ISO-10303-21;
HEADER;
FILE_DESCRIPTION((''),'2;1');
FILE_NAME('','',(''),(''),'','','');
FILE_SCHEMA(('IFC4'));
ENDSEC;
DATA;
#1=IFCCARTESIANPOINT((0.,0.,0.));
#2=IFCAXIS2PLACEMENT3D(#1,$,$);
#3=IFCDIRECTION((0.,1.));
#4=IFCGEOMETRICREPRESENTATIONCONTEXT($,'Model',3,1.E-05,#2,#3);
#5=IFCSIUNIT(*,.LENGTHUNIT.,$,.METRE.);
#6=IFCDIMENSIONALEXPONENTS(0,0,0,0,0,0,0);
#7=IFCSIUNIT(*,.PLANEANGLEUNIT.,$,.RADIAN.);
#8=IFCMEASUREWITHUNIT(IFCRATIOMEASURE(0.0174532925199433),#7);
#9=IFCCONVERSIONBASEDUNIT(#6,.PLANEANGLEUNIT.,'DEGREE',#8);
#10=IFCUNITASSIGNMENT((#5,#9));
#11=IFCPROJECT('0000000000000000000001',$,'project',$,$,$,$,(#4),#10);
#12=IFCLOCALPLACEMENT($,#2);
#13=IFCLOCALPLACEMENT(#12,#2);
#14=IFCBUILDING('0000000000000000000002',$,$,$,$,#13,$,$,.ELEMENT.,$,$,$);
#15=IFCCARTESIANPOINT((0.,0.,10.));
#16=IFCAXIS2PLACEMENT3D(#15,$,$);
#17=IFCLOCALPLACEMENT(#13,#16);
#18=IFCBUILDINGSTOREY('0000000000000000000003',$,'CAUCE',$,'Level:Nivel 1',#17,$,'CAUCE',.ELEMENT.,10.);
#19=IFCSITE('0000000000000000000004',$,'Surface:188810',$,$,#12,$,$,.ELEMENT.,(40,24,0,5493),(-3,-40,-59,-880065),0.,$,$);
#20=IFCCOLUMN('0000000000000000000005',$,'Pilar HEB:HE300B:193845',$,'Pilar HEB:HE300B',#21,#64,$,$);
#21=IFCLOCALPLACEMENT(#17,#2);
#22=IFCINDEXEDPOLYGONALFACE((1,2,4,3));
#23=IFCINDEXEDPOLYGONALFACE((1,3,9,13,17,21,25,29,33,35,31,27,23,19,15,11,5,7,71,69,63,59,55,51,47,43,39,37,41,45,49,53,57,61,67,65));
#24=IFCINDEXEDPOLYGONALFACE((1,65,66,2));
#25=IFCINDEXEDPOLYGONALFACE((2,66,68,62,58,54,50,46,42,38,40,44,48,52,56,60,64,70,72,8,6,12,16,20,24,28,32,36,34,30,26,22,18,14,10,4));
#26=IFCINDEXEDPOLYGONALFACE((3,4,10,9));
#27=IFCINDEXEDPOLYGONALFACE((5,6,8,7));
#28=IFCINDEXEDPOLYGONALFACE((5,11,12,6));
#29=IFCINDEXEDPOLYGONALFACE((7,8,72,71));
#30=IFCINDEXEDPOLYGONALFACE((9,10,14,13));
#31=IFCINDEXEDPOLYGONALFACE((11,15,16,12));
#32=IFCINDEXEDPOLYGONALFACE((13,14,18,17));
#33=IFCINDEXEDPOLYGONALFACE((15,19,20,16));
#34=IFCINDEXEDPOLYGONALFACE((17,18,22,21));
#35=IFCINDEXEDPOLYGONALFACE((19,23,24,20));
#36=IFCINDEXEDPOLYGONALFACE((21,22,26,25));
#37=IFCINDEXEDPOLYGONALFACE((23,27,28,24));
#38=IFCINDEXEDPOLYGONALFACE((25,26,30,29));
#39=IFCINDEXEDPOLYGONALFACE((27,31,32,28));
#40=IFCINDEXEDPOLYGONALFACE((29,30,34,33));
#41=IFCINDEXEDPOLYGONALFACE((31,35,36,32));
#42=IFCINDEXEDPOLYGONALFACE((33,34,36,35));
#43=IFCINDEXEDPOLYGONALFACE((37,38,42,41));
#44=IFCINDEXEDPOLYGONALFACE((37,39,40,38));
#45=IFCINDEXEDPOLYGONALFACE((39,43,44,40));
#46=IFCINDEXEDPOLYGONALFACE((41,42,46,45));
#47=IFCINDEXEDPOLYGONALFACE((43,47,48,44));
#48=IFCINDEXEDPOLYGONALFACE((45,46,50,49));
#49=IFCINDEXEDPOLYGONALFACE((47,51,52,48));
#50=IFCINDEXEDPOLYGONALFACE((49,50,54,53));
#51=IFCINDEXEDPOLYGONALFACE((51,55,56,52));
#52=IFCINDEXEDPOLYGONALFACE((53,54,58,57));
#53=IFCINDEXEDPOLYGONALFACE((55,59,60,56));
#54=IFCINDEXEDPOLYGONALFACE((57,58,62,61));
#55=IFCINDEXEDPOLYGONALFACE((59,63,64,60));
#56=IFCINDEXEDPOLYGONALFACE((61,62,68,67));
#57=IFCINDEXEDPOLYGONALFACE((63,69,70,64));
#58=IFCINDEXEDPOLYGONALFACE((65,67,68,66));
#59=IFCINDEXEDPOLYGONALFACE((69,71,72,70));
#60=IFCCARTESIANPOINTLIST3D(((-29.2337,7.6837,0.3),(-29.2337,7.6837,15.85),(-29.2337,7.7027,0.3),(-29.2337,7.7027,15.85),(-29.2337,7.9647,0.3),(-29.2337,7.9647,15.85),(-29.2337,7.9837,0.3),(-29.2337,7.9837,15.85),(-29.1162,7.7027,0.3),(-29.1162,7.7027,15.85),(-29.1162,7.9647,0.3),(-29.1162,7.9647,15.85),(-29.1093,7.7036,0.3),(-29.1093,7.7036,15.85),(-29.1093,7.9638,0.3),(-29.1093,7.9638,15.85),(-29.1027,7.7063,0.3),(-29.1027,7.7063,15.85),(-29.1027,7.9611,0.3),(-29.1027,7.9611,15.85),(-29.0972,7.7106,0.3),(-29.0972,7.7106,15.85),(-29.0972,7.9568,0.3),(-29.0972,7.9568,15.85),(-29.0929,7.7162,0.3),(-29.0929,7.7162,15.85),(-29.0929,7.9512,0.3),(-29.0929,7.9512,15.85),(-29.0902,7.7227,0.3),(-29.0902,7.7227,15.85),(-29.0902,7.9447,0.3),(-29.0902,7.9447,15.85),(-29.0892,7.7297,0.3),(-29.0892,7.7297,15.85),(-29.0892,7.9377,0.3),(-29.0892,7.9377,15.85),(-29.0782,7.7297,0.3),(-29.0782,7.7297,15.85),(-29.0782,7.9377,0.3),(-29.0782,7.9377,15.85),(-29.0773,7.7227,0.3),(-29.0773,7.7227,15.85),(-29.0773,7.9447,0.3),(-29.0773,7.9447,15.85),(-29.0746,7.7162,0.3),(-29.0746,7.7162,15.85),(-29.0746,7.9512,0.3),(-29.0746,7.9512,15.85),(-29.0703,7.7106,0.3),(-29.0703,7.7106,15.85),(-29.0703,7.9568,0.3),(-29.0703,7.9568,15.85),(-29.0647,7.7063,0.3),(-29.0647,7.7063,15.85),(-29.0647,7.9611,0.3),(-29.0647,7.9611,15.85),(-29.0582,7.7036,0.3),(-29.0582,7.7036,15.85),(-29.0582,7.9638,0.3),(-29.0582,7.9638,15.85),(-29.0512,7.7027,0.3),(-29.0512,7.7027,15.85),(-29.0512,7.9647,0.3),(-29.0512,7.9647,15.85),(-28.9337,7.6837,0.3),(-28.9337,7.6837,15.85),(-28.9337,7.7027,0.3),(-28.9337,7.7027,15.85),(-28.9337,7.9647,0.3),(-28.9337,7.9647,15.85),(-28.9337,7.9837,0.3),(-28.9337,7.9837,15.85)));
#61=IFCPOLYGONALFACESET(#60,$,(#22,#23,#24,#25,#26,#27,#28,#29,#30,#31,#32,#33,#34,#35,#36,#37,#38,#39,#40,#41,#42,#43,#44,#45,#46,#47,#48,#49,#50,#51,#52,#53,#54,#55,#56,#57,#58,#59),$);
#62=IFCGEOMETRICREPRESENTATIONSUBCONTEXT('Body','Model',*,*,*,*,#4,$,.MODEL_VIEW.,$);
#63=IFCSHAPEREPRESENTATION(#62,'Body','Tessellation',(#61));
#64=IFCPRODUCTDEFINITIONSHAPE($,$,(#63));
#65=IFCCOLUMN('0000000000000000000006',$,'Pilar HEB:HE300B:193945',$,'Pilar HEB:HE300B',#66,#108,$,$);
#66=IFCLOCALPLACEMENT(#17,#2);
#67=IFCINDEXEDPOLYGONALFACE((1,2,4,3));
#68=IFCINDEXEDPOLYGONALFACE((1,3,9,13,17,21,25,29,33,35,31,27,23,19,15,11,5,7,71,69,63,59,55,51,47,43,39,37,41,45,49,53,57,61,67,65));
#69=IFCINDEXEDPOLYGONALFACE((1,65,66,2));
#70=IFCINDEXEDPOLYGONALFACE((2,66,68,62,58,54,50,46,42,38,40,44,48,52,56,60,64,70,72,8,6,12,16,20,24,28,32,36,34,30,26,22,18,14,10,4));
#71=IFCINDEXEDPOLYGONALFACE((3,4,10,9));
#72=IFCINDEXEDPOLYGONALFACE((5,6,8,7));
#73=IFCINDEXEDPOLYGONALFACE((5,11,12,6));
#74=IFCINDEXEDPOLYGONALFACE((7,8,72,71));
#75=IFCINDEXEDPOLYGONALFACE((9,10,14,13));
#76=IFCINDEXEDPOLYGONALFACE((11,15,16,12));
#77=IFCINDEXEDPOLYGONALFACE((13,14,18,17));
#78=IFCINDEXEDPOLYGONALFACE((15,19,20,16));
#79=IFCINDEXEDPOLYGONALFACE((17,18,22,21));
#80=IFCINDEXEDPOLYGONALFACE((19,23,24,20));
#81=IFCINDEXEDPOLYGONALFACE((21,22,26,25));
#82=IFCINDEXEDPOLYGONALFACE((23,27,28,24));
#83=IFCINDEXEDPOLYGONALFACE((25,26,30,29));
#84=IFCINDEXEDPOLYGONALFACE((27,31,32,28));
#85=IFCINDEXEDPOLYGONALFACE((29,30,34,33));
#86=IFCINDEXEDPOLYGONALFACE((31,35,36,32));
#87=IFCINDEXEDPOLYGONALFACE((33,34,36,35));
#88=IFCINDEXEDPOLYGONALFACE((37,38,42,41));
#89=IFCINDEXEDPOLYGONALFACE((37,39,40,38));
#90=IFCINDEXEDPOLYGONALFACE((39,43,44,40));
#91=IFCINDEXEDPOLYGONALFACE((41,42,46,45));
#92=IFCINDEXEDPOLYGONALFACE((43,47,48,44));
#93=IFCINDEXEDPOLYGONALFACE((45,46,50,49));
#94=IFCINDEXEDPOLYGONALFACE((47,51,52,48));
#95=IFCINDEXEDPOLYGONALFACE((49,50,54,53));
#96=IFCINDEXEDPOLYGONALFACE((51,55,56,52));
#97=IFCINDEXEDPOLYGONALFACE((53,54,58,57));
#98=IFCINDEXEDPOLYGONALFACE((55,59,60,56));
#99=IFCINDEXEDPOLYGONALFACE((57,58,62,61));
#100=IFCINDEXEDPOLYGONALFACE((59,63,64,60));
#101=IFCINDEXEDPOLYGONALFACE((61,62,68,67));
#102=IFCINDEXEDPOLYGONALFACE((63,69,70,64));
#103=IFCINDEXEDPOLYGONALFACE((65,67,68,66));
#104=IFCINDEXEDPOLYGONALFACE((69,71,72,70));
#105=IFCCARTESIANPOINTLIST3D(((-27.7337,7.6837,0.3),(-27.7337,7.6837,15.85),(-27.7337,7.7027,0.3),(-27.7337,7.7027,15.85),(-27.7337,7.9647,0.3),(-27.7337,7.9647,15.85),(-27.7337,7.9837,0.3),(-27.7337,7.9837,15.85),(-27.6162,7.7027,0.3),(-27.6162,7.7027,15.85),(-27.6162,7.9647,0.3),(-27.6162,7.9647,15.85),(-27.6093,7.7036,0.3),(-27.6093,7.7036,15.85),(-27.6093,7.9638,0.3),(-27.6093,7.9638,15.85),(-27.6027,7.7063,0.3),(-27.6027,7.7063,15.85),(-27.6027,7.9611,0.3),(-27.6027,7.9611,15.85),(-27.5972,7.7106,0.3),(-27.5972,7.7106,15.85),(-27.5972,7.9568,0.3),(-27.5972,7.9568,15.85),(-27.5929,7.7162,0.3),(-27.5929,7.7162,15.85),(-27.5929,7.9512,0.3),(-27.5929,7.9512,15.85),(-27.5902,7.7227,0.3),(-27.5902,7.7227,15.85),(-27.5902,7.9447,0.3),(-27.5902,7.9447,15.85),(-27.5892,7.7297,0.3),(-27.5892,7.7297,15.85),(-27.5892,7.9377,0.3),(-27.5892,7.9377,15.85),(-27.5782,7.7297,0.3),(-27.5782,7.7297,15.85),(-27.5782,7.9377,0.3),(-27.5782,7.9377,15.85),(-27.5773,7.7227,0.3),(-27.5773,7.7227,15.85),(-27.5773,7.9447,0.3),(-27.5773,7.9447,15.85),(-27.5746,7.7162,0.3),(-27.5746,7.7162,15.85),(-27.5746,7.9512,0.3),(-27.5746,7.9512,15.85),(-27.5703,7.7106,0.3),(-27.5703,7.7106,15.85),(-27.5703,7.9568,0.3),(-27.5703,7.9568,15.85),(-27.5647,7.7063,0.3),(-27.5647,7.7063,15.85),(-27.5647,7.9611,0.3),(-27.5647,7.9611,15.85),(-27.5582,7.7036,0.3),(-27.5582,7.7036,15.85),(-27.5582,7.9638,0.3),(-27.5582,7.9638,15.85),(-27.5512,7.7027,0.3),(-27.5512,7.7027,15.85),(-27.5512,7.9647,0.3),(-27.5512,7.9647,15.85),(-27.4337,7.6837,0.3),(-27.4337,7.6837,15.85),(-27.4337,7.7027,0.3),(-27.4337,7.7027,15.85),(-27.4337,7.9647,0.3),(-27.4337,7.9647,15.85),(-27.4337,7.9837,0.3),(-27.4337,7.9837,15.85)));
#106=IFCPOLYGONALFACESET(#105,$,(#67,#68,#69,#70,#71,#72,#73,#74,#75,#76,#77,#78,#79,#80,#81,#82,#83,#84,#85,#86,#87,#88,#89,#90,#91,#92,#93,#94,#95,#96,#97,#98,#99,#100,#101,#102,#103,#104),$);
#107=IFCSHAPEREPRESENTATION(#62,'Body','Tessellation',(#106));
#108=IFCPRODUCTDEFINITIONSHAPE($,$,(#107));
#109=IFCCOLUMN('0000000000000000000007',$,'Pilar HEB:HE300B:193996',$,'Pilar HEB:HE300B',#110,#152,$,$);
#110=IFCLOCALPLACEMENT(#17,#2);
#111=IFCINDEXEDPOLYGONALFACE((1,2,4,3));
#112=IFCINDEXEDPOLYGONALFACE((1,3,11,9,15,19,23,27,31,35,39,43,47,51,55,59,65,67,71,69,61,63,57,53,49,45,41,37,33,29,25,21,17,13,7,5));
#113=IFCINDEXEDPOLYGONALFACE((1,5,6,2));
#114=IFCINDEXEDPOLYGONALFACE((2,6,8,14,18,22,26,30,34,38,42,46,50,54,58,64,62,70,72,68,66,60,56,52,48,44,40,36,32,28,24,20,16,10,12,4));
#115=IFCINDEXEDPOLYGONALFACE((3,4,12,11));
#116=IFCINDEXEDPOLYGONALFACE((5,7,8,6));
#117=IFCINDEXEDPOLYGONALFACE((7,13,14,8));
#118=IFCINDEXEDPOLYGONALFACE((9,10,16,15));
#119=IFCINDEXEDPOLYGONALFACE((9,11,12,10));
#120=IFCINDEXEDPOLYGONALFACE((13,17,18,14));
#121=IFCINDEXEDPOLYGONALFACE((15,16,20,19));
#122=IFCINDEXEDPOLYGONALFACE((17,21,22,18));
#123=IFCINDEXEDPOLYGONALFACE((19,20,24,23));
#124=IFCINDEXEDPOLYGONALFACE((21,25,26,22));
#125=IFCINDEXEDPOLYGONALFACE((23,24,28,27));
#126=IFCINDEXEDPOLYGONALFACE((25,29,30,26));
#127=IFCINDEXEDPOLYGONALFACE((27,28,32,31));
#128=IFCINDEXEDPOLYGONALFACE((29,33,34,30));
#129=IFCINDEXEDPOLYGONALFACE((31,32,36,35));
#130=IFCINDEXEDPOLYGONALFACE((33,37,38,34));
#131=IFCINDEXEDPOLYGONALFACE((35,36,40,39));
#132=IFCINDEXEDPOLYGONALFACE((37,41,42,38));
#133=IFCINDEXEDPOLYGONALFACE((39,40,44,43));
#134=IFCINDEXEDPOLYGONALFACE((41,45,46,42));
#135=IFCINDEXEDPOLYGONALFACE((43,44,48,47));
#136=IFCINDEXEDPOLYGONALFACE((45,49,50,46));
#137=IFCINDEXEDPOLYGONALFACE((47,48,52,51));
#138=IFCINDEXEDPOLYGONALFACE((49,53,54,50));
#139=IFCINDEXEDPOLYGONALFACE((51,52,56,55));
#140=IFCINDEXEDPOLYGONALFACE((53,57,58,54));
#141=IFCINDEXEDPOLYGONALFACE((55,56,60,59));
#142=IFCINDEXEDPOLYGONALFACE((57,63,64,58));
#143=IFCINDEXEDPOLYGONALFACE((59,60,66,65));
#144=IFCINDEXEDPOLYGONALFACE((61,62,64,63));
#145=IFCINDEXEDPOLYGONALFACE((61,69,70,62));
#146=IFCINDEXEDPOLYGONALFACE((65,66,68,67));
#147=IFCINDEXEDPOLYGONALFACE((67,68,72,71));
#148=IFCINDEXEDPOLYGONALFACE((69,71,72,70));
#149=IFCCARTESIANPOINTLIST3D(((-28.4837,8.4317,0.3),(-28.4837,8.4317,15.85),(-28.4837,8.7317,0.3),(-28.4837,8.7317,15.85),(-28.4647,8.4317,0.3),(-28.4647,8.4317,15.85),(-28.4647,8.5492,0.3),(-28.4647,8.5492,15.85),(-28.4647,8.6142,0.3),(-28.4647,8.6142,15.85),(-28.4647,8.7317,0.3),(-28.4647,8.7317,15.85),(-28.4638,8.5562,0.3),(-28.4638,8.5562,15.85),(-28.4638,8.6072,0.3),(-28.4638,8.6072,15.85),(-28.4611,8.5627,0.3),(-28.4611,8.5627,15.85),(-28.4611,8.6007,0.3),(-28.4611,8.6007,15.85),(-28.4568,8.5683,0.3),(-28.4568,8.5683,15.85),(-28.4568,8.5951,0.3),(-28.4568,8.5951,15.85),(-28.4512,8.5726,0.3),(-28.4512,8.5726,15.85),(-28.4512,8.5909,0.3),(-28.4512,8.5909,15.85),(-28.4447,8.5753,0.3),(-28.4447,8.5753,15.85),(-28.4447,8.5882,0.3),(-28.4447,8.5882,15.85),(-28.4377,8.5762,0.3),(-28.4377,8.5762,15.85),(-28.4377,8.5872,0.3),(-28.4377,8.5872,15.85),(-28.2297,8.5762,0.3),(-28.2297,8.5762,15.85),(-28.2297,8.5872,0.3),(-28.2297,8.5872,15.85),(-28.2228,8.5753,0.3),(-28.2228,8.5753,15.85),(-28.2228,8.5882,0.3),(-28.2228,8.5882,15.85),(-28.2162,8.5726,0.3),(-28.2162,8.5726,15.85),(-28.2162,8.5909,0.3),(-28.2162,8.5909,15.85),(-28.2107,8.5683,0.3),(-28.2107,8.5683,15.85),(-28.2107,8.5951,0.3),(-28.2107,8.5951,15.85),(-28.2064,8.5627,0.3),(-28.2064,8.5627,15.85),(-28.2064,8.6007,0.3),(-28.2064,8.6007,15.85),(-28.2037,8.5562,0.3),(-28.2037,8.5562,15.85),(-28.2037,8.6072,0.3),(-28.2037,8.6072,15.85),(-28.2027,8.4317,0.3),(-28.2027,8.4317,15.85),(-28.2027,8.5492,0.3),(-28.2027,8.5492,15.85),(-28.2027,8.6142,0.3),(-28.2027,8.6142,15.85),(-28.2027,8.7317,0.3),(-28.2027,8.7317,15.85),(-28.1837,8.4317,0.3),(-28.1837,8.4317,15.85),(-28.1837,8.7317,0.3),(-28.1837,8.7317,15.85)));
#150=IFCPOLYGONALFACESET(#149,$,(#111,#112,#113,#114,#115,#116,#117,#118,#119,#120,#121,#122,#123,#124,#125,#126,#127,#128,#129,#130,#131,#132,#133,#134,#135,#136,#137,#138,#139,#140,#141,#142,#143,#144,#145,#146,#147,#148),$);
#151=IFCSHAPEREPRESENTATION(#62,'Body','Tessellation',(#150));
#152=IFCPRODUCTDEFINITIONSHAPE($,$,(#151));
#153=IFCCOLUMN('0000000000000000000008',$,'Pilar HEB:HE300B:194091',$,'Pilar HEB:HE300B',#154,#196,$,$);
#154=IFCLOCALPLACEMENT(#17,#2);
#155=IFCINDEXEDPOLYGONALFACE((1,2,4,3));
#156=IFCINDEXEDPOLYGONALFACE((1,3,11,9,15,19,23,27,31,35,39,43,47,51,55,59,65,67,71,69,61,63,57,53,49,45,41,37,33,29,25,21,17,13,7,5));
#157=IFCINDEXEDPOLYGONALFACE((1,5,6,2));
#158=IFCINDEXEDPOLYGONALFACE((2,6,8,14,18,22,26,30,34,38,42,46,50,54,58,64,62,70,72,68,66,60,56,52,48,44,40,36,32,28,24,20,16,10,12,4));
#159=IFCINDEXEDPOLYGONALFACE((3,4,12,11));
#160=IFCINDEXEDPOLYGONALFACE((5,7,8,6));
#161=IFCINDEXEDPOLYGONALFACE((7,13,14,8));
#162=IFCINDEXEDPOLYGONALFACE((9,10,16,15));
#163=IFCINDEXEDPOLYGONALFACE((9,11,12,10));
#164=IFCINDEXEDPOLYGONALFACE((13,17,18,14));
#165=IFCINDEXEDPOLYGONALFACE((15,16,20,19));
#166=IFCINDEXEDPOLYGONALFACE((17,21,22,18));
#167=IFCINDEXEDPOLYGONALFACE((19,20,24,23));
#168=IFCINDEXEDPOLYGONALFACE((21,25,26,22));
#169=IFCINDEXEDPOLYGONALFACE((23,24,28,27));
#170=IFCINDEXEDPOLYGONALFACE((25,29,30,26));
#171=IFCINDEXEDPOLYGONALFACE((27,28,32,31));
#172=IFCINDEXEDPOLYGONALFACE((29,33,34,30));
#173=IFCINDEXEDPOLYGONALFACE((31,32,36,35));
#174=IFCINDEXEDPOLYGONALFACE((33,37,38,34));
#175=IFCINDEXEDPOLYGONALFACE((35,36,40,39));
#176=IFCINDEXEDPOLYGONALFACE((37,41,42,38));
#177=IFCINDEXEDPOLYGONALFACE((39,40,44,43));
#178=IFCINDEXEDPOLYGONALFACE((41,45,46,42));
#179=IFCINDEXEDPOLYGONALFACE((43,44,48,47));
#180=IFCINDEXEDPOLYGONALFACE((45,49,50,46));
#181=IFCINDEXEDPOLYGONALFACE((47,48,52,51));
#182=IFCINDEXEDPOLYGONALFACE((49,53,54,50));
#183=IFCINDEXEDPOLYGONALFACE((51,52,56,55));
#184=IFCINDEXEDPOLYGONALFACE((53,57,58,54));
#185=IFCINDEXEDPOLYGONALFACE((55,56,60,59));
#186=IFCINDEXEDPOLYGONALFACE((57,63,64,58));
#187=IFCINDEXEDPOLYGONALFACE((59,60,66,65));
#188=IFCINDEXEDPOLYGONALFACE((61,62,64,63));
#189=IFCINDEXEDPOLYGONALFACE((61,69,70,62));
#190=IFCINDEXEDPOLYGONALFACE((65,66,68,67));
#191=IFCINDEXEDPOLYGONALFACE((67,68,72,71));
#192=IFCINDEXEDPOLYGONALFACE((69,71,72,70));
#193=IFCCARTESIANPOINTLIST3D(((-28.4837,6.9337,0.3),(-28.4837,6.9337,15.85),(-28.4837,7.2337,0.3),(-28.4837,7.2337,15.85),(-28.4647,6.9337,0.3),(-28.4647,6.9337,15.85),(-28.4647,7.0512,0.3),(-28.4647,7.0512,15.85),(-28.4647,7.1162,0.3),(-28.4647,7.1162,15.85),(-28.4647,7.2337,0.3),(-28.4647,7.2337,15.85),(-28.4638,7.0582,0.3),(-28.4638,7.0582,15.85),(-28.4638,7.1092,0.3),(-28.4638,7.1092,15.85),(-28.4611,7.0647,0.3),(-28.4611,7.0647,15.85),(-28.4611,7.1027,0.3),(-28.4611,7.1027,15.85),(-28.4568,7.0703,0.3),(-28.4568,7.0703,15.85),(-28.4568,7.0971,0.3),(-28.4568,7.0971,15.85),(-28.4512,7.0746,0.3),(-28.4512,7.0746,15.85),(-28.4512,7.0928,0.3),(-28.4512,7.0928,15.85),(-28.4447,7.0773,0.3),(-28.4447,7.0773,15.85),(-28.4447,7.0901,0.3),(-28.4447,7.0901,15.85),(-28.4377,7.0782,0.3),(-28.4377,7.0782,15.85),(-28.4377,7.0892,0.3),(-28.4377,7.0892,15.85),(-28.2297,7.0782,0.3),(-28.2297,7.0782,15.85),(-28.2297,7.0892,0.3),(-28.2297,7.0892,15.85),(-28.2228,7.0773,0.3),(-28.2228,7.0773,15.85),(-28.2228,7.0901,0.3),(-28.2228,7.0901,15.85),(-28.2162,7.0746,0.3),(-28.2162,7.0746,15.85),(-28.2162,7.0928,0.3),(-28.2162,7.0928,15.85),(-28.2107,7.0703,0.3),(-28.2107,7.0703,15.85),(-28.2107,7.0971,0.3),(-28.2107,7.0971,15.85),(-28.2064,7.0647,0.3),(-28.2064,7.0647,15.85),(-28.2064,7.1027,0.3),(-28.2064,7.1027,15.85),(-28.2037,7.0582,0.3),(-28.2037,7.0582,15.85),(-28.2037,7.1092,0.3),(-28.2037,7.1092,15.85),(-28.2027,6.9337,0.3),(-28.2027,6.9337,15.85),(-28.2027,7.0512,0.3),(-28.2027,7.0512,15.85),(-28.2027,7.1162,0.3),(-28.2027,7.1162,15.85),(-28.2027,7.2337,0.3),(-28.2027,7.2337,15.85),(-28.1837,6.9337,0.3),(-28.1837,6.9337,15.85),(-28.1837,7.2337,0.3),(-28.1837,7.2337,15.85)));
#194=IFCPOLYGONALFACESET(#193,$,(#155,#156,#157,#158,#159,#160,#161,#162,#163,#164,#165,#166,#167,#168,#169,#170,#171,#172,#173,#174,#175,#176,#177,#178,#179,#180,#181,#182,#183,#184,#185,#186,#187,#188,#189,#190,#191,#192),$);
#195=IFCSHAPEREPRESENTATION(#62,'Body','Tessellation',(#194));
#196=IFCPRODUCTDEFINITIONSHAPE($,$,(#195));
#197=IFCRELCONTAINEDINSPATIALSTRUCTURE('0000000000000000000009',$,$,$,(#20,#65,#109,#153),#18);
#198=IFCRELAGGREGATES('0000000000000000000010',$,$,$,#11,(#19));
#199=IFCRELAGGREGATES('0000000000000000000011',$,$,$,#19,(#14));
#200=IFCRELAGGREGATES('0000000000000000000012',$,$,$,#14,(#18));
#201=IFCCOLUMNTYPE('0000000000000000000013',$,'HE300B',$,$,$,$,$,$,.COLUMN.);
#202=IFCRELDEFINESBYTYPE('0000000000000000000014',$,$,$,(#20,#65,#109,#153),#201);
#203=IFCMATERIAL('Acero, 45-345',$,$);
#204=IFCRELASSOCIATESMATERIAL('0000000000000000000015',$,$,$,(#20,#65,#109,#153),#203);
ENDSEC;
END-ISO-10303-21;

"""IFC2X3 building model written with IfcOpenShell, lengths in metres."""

from ifc_helpers import new_model, entity, si_unit, converted_unit, direction, frame, frame_2d, origin, place, context, subcontext, project, spatial, i_section, extrude, source, transform, mapped, material, type_object, type_shapes, element, save


model = new_model("IFC2X3")

# Units and contexts
model_context = context("Model", 3, precision=1e-05, world=origin(), true_north=direction((0.0, 1.0)))
body_context = subcontext(model_context, "Body", "Model", "MODEL_VIEW")
ifc_project = project(units=[si_unit("LENGTHUNIT", "METRE"), converted_unit("PLANEANGLEUNIT", "DEGREE", entity("IfcRatioMeasure", 0.0174532925199433), si_unit("PLANEANGLEUNIT", "RADIAN"), dimensions=[0, 0, 0, 0, 0, 0, 0])], contexts=[model_context])

# Site, building, storey
site_placement = place(None, origin())
site = spatial("IfcSite", under=ifc_project, at=site_placement, Name="Surface:188810", CompositionType="ELEMENT", RefLatitude=(40, 24, 0, 5493), RefLongitude=(-3, -40, -59, -880065), RefElevation=0.0)
building_placement = place(site_placement, origin())
building = spatial("IfcBuilding", under=site, at=building_placement, CompositionType="ELEMENT")
storey_placement = place(building_placement, frame((0.0, 0.0, 10.0)))
storey = spatial("IfcBuildingStorey", under=building, at=storey_placement, Name="CAUCE", ObjectType="Level:Nivel 1", LongName="CAUCE", CompositionType="ELEMENT", Elevation=10.0)

# Columns
ifc_material_1 = material(Name="Acero, 45-345")
column_type_1 = type_object("IfcColumnType", Name="HE300B", PredefinedType="COLUMN")
shared_shape_1 = source(origin(), body_context, "Body", "SweptSolid", [
    extrude(i_section(OverallWidth=0.3, OverallDepth=0.3, WebThickness=0.011, FlangeThickness=0.019, FilletRadius=0.027, at=frame_2d((0.0, 0.0), x_axis=(0.0, 1.0))), frame((0.0, 0.0, 10.3), z_axis=(0.0, 0.0, 1.0), x_axis=(0.0, -1.0, 0.0)), (0.0, 0.0, 1.0), 15.55),
])
type_shapes(column_type_1, [shared_shape_1])
for number, where, name in (
    (1, (-29.0837, 7.8337, -10.0), "Pilar HEB:HE300B:193845"),
    (2, (-27.5837, 7.8337, -10.0), "Pilar HEB:HE300B:193945"),
):
    element("IfcColumn", number, at=place(storey_placement, frame(where)), inside=storey, type_object=column_type_1, material=ifc_material_1, Name=name, ObjectType="Pilar HEB:HE300B", context=body_context, shape_type="MappedRepresentation", body=[
        mapped(shared_shape_1, transform((0.0, 0.0, 0.0), scale=1.0)),
    ])
for number, where, z_axis, x_axis, name in (
    (3, (-28.3337, 8.5817, -10.0), (0.0, 0.0, 1.0), (0.0, 1.0, 0.0), "Pilar HEB:HE300B:193996"),
    (4, (-28.3337, 7.0837, -10.0), (0.0, 0.0, 1.0), (0.0, 1.0, 0.0), "Pilar HEB:HE300B:194091"),
):
    element("IfcColumn", number, at=place(storey_placement, frame(where, z_axis=z_axis, x_axis=x_axis)), inside=storey, type_object=column_type_1, material=ifc_material_1, Name=name, ObjectType="Pilar HEB:HE300B", context=body_context, shape_type="MappedRepresentation", body=[
        mapped(shared_shape_1, transform((0.0, 0.0, 0.0), scale=1.0)),
    ])

save(model, "model.ifc")
